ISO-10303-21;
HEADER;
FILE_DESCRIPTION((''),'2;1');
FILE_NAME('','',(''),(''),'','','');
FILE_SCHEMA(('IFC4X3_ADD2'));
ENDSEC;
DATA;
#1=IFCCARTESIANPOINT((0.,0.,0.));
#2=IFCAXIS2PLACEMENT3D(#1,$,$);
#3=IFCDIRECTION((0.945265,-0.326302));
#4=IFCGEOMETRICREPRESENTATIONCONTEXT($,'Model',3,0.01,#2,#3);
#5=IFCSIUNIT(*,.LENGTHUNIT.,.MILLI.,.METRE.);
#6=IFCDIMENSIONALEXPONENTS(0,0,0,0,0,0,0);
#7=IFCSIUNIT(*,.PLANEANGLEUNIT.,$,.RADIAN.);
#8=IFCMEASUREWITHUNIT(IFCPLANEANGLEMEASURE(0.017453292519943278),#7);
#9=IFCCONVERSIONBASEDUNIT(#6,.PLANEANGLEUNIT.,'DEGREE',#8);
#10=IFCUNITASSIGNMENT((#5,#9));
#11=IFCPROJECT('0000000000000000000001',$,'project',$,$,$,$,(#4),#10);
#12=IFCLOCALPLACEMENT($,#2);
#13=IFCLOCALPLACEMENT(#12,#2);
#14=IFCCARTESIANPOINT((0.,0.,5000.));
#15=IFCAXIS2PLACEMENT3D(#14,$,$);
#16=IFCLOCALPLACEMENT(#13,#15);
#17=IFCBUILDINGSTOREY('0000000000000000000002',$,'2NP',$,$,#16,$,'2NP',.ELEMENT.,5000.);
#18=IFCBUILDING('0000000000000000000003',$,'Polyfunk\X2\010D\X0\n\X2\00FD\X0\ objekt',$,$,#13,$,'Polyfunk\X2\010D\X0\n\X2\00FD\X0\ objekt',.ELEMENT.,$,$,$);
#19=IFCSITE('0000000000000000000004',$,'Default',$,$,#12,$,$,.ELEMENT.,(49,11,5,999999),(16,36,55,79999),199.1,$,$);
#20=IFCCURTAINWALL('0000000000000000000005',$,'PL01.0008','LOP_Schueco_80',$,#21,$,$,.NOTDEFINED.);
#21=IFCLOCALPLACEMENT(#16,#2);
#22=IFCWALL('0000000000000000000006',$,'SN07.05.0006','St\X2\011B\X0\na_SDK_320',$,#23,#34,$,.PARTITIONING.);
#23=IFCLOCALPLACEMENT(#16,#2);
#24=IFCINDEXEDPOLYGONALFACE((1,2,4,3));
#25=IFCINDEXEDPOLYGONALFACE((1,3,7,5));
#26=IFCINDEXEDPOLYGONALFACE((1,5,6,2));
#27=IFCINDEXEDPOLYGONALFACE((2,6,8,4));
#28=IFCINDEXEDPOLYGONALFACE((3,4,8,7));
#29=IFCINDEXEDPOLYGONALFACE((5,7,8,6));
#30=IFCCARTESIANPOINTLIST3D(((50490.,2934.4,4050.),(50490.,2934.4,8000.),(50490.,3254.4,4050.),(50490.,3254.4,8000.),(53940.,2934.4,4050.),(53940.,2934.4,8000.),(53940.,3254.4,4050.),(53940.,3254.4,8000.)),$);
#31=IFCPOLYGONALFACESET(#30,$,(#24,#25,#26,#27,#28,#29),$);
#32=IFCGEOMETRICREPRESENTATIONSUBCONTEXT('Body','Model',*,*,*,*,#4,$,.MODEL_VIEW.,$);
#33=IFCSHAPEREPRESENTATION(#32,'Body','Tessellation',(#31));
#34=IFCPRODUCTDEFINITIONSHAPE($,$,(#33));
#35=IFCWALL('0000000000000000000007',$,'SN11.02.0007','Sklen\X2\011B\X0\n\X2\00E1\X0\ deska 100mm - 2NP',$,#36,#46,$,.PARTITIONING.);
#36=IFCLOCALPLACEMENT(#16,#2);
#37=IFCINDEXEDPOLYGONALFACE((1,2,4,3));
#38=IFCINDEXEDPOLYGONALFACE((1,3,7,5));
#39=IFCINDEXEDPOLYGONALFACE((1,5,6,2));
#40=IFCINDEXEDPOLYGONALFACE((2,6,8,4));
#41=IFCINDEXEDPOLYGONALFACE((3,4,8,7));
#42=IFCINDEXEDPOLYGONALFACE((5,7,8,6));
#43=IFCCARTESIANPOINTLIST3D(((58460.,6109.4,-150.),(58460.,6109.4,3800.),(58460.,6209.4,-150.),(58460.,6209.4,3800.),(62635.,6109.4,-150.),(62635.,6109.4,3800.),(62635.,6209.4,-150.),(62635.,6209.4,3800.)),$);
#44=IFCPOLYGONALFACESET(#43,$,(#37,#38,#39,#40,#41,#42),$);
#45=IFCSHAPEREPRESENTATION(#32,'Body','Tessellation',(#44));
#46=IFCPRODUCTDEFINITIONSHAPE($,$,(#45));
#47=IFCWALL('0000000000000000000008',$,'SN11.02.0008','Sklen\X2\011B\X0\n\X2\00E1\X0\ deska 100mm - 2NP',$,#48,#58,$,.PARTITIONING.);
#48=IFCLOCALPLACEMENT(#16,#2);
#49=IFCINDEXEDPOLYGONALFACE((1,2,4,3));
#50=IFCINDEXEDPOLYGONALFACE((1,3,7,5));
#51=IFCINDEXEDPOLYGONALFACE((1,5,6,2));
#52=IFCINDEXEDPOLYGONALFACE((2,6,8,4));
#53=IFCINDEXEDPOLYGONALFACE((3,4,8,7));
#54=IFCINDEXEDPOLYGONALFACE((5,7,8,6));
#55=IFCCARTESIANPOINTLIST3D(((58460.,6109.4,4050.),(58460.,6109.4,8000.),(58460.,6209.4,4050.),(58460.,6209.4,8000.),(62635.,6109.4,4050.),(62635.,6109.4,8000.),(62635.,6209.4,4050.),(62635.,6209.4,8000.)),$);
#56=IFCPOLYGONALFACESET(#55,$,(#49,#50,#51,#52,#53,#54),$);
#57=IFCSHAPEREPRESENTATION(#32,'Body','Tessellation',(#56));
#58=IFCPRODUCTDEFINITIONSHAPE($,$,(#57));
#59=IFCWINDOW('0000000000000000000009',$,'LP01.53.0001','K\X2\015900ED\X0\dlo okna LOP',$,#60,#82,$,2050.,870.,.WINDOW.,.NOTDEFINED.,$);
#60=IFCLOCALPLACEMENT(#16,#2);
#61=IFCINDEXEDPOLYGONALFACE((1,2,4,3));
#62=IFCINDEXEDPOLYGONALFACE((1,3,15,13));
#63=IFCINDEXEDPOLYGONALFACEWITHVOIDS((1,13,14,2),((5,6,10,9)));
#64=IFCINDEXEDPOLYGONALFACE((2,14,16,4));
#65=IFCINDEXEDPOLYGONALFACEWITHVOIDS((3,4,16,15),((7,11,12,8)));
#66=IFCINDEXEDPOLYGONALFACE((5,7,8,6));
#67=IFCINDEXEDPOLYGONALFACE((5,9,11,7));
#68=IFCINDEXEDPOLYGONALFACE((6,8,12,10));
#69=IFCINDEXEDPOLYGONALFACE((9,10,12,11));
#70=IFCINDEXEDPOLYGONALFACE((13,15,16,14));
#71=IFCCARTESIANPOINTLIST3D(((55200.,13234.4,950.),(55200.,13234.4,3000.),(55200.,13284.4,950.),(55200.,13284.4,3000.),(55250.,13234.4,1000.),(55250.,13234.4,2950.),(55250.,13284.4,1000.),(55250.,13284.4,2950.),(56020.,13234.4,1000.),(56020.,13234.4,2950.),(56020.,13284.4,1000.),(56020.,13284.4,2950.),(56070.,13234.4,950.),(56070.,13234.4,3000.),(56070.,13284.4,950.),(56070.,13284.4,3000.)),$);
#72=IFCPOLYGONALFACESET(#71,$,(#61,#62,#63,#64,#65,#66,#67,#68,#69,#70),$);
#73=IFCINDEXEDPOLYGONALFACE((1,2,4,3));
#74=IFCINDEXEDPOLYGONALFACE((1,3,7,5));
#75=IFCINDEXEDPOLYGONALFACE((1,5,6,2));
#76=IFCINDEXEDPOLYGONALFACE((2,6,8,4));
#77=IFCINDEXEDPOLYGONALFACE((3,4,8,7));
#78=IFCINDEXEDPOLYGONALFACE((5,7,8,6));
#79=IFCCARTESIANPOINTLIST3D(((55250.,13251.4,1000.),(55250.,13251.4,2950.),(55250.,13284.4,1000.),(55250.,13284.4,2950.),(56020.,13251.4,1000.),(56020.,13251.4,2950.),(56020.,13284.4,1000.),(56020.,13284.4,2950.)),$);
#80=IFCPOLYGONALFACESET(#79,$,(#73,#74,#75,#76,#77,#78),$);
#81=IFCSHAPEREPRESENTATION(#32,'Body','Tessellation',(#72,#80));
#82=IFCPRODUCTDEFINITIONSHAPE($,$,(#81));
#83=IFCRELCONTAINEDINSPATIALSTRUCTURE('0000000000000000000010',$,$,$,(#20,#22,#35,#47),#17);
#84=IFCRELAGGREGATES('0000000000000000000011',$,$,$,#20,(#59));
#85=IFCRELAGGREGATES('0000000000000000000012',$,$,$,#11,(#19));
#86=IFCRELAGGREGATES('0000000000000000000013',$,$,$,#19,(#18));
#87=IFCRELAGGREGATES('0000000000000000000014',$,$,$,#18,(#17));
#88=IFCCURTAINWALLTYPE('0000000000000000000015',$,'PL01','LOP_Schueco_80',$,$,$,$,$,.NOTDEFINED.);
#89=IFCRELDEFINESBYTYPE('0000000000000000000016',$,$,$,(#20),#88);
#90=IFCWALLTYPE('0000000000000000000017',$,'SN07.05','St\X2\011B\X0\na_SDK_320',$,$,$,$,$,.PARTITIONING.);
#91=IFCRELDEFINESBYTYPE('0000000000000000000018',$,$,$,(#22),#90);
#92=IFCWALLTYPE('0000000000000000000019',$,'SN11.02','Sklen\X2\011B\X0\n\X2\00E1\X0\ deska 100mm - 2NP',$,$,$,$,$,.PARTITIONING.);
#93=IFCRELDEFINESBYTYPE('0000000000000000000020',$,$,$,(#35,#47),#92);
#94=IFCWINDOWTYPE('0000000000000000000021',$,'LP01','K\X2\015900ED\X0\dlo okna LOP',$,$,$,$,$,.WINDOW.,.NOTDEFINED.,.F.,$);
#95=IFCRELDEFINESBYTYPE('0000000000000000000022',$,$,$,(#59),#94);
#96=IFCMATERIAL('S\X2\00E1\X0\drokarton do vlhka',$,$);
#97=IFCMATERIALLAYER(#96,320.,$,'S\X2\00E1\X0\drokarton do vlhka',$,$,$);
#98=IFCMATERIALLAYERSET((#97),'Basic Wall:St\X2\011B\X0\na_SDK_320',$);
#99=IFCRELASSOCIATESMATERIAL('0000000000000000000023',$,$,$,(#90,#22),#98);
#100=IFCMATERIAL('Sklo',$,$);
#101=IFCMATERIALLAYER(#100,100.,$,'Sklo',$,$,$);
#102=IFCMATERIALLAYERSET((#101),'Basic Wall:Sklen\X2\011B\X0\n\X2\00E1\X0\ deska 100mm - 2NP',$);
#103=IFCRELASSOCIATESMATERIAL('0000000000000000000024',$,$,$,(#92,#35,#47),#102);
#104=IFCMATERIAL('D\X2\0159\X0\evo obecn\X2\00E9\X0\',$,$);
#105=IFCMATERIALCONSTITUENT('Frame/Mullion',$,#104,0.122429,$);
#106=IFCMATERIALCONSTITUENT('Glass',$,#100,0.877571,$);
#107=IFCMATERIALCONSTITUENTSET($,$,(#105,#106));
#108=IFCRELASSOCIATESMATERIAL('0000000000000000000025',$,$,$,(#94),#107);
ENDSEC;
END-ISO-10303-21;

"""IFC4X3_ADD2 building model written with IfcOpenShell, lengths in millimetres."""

from ifc_helpers import new_model, entity, si_unit, converted_unit, direction, frame, frame_2d, origin, origin_2d_with_axis, place, context, subcontext, project, spatial, polyline, rectangle, outline, extrude, clip, bounded_halfspace, source, transform, mapped, material, layer, layer_set, constituent, constituent_set, type_object, type_shapes, element, aggregate, save


model = new_model("IFC4X3_ADD2")

# Units and contexts
model_context = context("Model", 3, precision=0.01, world=origin(), true_north=direction((0.945265, -0.326302)))
body_context = subcontext(model_context, "Body", "Model", "MODEL_VIEW")
ifc_project = project(units=[si_unit("LENGTHUNIT", "METRE", prefix="MILLI"), converted_unit("PLANEANGLEUNIT", "DEGREE", entity("IfcPlaneAngleMeasure", 0.017453292519943278), si_unit("PLANEANGLEUNIT", "RADIAN"), dimensions=[0, 0, 0, 0, 0, 0, 0])], contexts=[model_context])

# Site, building, storey
site_placement = place(None, origin())
site = spatial("IfcSite", under=ifc_project, at=site_placement, Name="Default", CompositionType="ELEMENT", RefLatitude=(49, 11, 5, 999999), RefLongitude=(16, 36, 55, 79999), RefElevation=199.1)
building_placement = place(site_placement, origin())
building = spatial("IfcBuilding", under=site, at=building_placement, Name="Polyfunkčný objekt", LongName="Polyfunkčný objekt", CompositionType="ELEMENT")
storey_placement = place(building_placement, frame((0.0, 0.0, 5000.0)))
storey = spatial("IfcBuildingStorey", under=building, at=storey_placement, Name="2NP", LongName="2NP", CompositionType="ELEMENT", Elevation=5000.0)

# Curtain wall
curtain_wall_type = type_object("IfcCurtainWallType", Name="PL01", Description="LOP_Schueco_80", PredefinedType="NOTDEFINED")
curtain_wall_placement = place(storey_placement, frame((0.0, 0.0, -5000.0)))
curtain_wall = element("IfcCurtainWall", 1, at=curtain_wall_placement, inside=storey, type_object=curtain_wall_type, Name="PL01.0008", Description="LOP_Schueco_80", PredefinedType="NOTDEFINED")
ifc_material_1 = material(Name="Sklo")

# Walls
ifc_material_2 = material(Name="Sádrokarton do vlhka")
ifc_layer_1 = layer(ifc_material_2, 320.0, Name="Sádrokarton do vlhka")
ifc_layer_set_1 = layer_set([ifc_layer_1], Name="Basic Wall:Stěna_SDK_320")
wall_type_1 = type_object("IfcWallType", Name="SN07.05", Description="Stěna_SDK_320", PredefinedType="PARTITIONING", material=ifc_layer_set_1)
wall_1_placement = place(storey_placement, frame((53940.0, 3094.4, 4050.0), z_axis=(0.0, 0.0, 1.0), x_axis=(-1.0, 0.0, 0.0)))
element("IfcWall", 2, at=wall_1_placement, inside=storey, type_object=wall_type_1, material=ifc_layer_set_1, Name="SN07.05.0006", Description="Stěna_SDK_320", PredefinedType="PARTITIONING", context=body_context, shape_type="Clipping", body=[
    clip(clip(extrude(rectangle(XDim=3450.0, YDim=320.0, at=frame_2d((1725.0, 0.0), x_axis=(-1.0, 0.0))), origin(), (0.0, 0.0, 1.0), 3950.0), bounded_halfspace(frame((3450.0, -160.0, 0.0)), True, frame((3450.0, -160.0, 0.0)), polyline([(0.0, 0.0), (0.0, 320.0), (-1650.0, 320.0), (-1800.0, 320.0), (-3450.0, 320.0), (-3450.0, 0.0), (-1800.0, 0.0), (-1650.0, 0.0), (0.0, 0.0)]))), bounded_halfspace(frame((0.0, -160.0, 3950.0), z_axis=(0.0, 0.0, -1.0), x_axis=(-1.0, 0.0, 0.0)), True, frame((0.0, -160.0, 3950.0)), polyline([(0.0, 0.0), (1650.0, 0.0), (1800.0, 0.0), (3450.0, 0.0), (3450.0, 320.0), (1800.0, 320.0), (1650.0, 320.0), (0.0, 320.0), (0.0, 0.0)]))),
])
ifc_layer_2 = layer(ifc_material_1, 100.0, Name="Sklo")
ifc_layer_set_2 = layer_set([ifc_layer_2], Name="Basic Wall:Skleněná deska 100mm - 2NP")
wall_type_2 = type_object("IfcWallType", Name="SN11.02", Description="Skleněná deska 100mm - 2NP", PredefinedType="PARTITIONING", material=ifc_layer_set_2)
wall_2_placement = place(storey_placement, frame((58460.0, 6159.4, -150.0)))
element("IfcWall", 3, at=wall_2_placement, inside=storey, type_object=wall_type_2, material=ifc_layer_set_2, Name="SN11.02.0007", Description="Skleněná deska 100mm - 2NP", PredefinedType="PARTITIONING", context=body_context, shape_type="Clipping", body=[
    clip(clip(extrude(rectangle(XDim=4175.0, YDim=100.0, at=frame_2d((2087.5, 0.0), x_axis=(-1.0, 0.0))), origin(), (0.0, 0.0, 1.0), 3950.0), bounded_halfspace(frame((4175.0, -50.0, 0.0), z_axis=(0.0, 0.0, 1.0), x_axis=(-1.0, 0.0, 0.0)), True, frame((4175.0, -50.0, 0.0)), polyline([(0.0, 0.0), (0.0, 100.0), (-4175.0, 100.0), (-4175.0, 0.0), (-4075.0, 0.0), (0.0, 0.0)]))), bounded_halfspace(frame((0.0, -50.0, 3950.0), z_axis=(0.0, 0.0, -1.0), x_axis=(1.0, 0.0, 0.0)), True, frame((0.0, -50.0, 3950.0)), polyline([(0.0, 0.0), (100.0, 0.0), (4175.0, 0.0), (4175.0, 100.0), (0.0, 100.0), (0.0, 0.0)]))),
])
wall_3_placement = place(storey_placement, frame((58460.0, 6159.4, 4050.0)))
element("IfcWall", 4, at=wall_3_placement, inside=storey, type_object=wall_type_2, material=ifc_layer_set_2, Name="SN11.02.0008", Description="Skleněná deska 100mm - 2NP", PredefinedType="PARTITIONING", context=body_context, shape_type="Clipping", body=[
    clip(clip(extrude(rectangle(XDim=4175.0, YDim=100.0, at=frame_2d((2087.5, 0.0), x_axis=(-1.0, 0.0))), origin(), (0.0, 0.0, 1.0), 3950.0), bounded_halfspace(frame((4175.0, -50.0, 0.0), z_axis=(0.0, 0.0, 1.0), x_axis=(-1.0, 0.0, 0.0)), True, frame((4175.0, -50.0, 0.0)), polyline([(0.0, 0.0), (0.0, 100.0), (-4175.0, 100.0), (-4175.0, 0.0), (-4075.0, 0.0), (0.0, 0.0)]))), bounded_halfspace(frame((0.0, -50.0, 3950.0), z_axis=(0.0, 0.0, -1.0), x_axis=(1.0, 0.0, 0.0)), True, frame((0.0, -50.0, 3950.0)), polyline([(0.0, 0.0), (100.0, 0.0), (4175.0, 0.0), (4175.0, 100.0), (0.0, 100.0), (0.0, 0.0)]))),
])

# Window
ifc_material_3 = material(Name="Dřevo obecné")
ifc_constituent_1 = constituent(ifc_material_3, Name="Frame/Mullion", fraction=0.122429)
ifc_constituent_2 = constituent(ifc_material_1, Name="Glass", fraction=0.877571)
ifc_constituent_set = constituent_set(constituents=[ifc_constituent_1, ifc_constituent_2])
window_type = type_object("IfcWindowType", Name="LP01", Description="Křídlo okna LOP", ParameterTakesPrecedence=False, PartitioningType="NOTDEFINED", PredefinedType="WINDOW", material=ifc_constituent_set)
shared_shape_1 = source(origin(), body_context, "Body", "SweptSolid", [
    extrude(outline(polyline([(-1025.0, -435.0), (1025.0, -435.0), (1025.0, 435.0), (-1025.0, 435.0), (-1025.0, -435.0)]), holes=[polyline([(-975.0, -385.0), (-975.0, 385.0), (975.0, 385.0), (975.0, -385.0), (-975.0, -385.0)])]), frame((0.0, 0.0, 1025.0), z_axis=(0.0, 1.0, 0.0), x_axis=(0.0, 0.0, -1.0)), (0.0, 0.0, 1.0), 50.0),
    extrude(rectangle(XDim=33.0, YDim=770.0, at=origin_2d_with_axis()), frame((0.0, 33.5, 50.0), z_axis=(0.0, 0.0, 1.0), x_axis=(0.0, -1.0, 0.0)), (0.0, 0.0, 1.0), 1950.0),
])
type_shapes(window_type, [shared_shape_1])
window_placement = place(curtain_wall_placement, frame((55635.0, 13234.4, 5950.0)))
window = element("IfcWindow", 5, at=window_placement, type_object=window_type, Name="LP01.53.0001", Description="Křídlo okna LOP", OverallHeight=2050.0, OverallWidth=870.0, PartitioningType="NOTDEFINED", PredefinedType="WINDOW", context=body_context, shape_type="MappedRepresentation", body=[
    mapped(shared_shape_1, transform((0.0, 0.0, 0.0), scale=1.0)),
])
aggregate(curtain_wall, [window])

save(model, "model.ifc")
